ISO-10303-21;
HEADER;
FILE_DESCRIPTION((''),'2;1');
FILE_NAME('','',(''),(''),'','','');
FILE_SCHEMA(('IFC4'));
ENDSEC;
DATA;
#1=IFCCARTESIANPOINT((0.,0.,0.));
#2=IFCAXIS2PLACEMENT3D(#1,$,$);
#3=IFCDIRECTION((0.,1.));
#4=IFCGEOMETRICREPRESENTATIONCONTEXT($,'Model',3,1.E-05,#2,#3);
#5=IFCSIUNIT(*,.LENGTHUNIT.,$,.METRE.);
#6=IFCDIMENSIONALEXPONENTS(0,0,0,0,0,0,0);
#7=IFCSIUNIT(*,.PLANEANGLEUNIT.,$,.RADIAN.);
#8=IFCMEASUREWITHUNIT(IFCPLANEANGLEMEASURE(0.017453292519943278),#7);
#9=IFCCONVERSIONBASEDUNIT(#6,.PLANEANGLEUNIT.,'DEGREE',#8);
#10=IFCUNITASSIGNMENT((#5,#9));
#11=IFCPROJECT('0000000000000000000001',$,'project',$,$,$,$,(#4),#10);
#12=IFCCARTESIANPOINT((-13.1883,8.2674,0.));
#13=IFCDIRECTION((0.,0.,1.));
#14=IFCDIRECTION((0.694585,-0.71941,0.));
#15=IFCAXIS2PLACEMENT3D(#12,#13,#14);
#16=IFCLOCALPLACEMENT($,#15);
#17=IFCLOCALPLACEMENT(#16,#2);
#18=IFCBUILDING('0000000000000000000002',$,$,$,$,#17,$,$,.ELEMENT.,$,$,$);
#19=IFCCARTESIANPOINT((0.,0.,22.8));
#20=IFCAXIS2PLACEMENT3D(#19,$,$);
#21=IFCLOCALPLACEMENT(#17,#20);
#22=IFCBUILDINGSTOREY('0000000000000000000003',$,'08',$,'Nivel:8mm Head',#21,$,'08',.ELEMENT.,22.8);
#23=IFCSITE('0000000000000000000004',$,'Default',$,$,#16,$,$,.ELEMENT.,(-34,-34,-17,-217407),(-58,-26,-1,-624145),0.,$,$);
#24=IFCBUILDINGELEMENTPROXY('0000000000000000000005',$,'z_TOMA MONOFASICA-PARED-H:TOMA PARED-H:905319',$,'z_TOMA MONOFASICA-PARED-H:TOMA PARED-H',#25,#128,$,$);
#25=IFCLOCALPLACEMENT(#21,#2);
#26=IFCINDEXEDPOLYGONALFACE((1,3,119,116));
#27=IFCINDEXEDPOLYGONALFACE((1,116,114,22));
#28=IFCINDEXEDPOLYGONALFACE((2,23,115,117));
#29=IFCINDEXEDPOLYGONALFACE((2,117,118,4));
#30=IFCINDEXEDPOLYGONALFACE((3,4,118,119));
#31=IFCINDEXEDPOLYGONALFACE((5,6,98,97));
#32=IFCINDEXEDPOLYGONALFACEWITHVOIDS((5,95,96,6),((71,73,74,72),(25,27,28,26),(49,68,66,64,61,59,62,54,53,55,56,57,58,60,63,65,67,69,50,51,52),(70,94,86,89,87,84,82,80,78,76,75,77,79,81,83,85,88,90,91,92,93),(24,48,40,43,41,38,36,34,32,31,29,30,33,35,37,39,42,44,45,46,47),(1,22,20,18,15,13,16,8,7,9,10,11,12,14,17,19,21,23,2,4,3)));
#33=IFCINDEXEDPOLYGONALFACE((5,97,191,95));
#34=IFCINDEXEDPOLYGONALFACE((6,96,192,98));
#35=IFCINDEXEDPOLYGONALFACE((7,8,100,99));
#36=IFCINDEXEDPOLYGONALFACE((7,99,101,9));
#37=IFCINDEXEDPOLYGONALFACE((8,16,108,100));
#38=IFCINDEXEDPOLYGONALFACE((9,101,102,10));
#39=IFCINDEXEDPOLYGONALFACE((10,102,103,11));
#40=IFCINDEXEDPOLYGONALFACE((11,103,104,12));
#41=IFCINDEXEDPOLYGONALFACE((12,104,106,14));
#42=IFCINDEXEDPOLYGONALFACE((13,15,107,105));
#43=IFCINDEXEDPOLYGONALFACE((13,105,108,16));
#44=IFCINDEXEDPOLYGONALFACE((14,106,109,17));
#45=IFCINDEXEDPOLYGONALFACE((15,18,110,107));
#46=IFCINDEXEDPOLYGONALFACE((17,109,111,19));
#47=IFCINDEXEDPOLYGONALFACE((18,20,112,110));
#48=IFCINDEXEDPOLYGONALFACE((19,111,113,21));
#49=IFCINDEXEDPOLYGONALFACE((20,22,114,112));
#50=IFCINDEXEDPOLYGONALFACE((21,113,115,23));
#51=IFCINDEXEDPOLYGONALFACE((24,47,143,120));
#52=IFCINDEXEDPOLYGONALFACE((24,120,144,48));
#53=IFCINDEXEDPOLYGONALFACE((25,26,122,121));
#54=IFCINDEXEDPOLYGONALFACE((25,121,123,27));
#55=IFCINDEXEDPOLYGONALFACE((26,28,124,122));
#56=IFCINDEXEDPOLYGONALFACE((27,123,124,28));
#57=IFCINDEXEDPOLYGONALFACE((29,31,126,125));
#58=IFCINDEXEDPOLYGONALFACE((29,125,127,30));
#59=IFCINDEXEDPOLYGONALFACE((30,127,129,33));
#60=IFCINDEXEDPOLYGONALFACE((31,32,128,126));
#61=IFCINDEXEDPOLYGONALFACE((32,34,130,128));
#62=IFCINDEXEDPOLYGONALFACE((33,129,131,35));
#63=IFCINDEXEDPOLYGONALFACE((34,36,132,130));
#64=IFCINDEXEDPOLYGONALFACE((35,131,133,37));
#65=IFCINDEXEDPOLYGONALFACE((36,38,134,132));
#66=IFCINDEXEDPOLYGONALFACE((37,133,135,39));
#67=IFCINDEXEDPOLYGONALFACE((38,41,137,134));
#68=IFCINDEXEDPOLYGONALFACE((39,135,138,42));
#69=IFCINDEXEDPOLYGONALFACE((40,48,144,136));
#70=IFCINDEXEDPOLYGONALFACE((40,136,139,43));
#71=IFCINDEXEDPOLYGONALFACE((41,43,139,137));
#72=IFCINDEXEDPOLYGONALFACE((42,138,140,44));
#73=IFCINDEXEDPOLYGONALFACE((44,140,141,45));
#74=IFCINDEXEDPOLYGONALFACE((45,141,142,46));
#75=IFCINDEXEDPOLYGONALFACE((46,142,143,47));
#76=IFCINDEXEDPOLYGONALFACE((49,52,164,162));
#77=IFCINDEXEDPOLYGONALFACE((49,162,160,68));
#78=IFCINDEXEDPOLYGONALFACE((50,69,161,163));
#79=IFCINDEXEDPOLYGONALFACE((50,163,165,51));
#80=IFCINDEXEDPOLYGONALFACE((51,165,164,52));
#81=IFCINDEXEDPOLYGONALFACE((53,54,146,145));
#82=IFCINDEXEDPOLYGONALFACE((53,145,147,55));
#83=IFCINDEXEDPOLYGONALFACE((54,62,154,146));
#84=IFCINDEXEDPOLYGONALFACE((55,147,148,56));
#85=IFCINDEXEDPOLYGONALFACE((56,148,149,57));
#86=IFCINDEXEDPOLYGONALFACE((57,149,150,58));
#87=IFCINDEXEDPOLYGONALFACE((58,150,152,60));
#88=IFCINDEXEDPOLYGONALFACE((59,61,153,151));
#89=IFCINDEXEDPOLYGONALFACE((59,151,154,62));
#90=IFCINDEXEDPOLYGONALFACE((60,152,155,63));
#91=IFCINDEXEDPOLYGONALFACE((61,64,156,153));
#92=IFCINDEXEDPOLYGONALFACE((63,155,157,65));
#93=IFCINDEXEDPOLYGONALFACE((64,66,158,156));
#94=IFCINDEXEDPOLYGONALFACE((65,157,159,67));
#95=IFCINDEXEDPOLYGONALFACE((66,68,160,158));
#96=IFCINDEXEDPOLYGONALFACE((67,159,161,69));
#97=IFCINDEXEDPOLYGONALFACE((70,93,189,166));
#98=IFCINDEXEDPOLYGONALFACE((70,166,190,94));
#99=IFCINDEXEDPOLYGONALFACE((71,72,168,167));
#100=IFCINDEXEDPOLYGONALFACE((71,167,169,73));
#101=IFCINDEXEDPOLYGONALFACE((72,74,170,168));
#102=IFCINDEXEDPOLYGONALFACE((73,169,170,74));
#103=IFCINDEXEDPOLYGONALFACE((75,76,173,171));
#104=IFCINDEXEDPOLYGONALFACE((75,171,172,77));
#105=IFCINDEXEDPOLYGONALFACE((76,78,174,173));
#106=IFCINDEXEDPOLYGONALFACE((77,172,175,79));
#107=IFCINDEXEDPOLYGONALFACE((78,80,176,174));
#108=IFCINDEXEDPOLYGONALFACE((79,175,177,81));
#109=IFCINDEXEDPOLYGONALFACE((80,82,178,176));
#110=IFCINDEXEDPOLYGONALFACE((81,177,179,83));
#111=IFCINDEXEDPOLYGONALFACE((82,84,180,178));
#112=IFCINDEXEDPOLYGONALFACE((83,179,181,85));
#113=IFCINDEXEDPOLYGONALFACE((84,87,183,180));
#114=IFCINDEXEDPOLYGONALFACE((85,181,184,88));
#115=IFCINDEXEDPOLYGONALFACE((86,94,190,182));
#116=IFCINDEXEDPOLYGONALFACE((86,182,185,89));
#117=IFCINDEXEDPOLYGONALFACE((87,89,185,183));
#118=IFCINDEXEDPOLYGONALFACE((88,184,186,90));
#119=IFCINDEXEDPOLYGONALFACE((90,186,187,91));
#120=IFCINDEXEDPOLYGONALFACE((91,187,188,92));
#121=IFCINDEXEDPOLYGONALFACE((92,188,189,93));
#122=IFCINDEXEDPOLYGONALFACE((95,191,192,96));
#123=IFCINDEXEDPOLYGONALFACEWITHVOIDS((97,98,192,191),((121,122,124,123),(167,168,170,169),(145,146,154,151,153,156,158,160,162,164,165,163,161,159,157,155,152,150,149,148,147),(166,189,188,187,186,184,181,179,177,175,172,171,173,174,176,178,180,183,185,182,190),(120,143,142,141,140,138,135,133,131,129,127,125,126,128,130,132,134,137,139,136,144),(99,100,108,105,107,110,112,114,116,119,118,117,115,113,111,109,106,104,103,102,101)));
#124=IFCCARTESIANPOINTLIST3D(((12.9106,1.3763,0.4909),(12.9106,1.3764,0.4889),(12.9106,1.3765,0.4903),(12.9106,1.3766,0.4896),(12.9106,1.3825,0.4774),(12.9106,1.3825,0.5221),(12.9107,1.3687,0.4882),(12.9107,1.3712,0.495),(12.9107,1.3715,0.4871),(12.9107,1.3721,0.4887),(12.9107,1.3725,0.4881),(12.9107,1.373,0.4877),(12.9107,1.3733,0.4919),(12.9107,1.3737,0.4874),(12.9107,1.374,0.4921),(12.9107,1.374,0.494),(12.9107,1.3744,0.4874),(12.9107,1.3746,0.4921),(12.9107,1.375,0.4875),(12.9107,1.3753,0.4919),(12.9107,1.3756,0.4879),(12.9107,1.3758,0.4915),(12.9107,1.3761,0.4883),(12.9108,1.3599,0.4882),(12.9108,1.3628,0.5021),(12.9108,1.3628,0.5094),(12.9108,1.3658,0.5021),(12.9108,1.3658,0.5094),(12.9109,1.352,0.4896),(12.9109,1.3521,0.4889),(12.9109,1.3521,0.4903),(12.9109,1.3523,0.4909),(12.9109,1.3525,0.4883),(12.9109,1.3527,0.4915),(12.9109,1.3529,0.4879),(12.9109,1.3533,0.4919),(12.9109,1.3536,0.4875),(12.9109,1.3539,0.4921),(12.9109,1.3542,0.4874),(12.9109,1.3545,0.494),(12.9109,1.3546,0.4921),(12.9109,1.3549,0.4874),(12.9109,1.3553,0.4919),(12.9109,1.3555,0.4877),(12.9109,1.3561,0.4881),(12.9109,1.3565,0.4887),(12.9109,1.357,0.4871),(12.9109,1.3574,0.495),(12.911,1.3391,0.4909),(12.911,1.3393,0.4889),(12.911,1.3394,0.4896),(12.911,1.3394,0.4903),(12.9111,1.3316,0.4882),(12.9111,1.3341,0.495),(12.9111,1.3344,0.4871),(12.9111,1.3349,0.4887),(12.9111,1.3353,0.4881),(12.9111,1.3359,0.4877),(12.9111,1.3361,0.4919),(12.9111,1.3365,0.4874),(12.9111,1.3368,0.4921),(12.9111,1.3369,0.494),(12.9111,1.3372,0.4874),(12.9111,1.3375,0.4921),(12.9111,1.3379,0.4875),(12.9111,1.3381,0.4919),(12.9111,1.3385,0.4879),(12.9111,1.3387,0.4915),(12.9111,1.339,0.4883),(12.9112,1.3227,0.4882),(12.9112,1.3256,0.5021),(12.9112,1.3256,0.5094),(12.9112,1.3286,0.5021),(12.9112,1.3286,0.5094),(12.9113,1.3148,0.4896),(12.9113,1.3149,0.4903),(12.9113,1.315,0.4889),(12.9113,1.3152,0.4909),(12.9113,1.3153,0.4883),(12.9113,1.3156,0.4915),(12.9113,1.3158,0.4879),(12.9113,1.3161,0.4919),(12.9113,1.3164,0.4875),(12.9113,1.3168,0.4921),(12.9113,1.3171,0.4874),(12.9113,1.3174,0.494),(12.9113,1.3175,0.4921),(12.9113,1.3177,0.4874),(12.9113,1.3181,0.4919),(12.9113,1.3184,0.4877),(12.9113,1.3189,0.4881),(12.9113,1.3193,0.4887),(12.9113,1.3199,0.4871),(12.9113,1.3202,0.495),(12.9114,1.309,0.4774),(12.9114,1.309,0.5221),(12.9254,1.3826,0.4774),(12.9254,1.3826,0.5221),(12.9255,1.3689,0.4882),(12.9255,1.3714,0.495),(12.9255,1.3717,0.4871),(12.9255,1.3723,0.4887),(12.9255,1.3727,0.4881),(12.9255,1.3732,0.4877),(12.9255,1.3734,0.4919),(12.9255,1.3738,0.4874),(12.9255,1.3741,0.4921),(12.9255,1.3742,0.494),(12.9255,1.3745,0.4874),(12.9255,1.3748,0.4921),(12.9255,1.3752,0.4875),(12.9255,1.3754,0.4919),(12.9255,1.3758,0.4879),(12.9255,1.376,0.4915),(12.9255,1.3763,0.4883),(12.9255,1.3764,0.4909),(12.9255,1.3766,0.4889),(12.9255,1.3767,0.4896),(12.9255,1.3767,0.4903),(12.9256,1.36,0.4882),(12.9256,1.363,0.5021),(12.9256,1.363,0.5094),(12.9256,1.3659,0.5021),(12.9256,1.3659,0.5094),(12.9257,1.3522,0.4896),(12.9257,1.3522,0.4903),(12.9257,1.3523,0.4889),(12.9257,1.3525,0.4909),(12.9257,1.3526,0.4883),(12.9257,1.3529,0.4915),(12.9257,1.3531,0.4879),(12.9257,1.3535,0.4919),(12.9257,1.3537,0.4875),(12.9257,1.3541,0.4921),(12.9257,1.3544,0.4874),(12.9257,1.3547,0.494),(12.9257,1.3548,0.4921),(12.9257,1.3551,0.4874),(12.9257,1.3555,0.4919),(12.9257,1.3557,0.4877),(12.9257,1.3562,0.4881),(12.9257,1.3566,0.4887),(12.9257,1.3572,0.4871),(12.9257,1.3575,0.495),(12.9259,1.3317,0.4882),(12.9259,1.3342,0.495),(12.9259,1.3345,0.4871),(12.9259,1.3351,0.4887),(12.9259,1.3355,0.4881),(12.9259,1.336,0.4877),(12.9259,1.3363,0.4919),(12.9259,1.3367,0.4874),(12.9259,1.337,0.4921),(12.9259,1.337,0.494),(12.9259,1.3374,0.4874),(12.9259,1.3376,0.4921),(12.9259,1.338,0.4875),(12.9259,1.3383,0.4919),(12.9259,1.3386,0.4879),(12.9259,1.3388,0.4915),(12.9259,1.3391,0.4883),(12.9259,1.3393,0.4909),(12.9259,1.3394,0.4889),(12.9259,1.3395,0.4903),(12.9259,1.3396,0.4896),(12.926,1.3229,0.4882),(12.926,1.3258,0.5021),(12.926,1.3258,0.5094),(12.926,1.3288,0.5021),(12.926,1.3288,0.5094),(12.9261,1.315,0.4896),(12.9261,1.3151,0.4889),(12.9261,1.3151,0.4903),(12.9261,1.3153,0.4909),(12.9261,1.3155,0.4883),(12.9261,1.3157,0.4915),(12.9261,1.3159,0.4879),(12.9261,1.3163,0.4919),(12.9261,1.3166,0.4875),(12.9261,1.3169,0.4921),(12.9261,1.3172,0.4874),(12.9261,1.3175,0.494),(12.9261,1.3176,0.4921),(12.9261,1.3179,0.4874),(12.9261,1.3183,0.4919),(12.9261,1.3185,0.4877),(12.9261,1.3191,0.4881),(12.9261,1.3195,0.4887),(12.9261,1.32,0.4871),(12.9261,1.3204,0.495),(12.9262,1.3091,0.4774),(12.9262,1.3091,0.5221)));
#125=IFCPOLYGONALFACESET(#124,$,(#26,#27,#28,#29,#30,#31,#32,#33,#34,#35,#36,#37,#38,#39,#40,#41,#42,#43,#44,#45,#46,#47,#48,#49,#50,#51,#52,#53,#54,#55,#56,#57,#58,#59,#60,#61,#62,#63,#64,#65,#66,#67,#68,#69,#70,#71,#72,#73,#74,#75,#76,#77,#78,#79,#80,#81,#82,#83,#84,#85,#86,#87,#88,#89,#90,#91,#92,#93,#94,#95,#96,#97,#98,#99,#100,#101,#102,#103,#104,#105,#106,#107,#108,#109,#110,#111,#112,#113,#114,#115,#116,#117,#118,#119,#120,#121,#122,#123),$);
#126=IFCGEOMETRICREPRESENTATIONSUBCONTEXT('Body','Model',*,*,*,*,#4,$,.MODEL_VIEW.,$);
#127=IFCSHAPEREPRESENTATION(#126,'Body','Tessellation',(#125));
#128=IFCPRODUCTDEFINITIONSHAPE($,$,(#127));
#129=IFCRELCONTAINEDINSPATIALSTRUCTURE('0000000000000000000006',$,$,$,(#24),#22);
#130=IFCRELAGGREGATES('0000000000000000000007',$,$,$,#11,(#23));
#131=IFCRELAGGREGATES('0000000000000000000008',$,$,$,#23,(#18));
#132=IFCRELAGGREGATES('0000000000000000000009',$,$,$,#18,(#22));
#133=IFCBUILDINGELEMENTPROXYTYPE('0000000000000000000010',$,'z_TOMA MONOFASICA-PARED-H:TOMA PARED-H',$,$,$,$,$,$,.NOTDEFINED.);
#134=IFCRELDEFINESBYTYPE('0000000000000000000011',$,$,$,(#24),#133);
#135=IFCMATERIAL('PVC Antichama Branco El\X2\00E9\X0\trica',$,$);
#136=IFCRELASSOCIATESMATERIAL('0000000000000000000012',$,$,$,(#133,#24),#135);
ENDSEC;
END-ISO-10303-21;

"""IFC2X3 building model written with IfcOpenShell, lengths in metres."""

from ifc_helpers import new_model, entity, si_unit, converted_unit, direction, frame, frame_2d, origin, place, context, subcontext, project, spatial, polyline, circle_curve, parameter, trimmed, segment, composite_curve, outline, extrude, source, transform, mapped, material, type_object, type_shapes, element, save


model = new_model("IFC2X3")

# Units and contexts
model_context = context("Model", 3, precision=1e-05, world=origin(), true_north=direction((0.0, 1.0)))
body_context = subcontext(model_context, "Body", "Model", "MODEL_VIEW")
ifc_project = project(units=[si_unit("LENGTHUNIT", "METRE"), converted_unit("PLANEANGLEUNIT", "DEGREE", entity("IfcPlaneAngleMeasure", 0.017453292519943278), si_unit("PLANEANGLEUNIT", "RADIAN"), dimensions=[0, 0, 0, 0, 0, 0, 0])], contexts=[model_context])

# Site, building, storey
site_placement = place(None, frame((-13.1883, 8.2674, 0.0), z_axis=(0.0, 0.0, 1.0), x_axis=(0.694585, -0.71941, 0.0)))
site = spatial("IfcSite", under=ifc_project, at=site_placement, Name="Default", CompositionType="ELEMENT", RefLatitude=(-34, -34, -17, -217407), RefLongitude=(-58, -26, -1, -624145), RefElevation=0.0)
building_placement = place(site_placement, origin())
building = spatial("IfcBuilding", under=site, at=building_placement, CompositionType="ELEMENT")
storey_placement = place(building_placement, frame((0.0, 0.0, 22.8)))
storey = spatial("IfcBuildingStorey", under=building, at=storey_placement, Name="08", ObjectType="Nivel:8mm Head", LongName="08", CompositionType="ELEMENT", Elevation=22.8)

# Building element proxy
ifc_material_1 = material(Name="PVC Antichama Branco Elétrica")
building_element_proxy_type_1 = type_object("IfcBuildingElementProxyType", Name="z_TOMA MONOFASICA-PARED-H:TOMA PARED-H", PredefinedType="NOTDEFINED", material=ifc_material_1)
shared_shape_1 = source(origin(), body_context, "Body", "SweptSolid", [
    extrude(outline(polyline([(-0.0368, -0.0223), (0.0368, -0.0223), (0.0368, 0.0223), (-0.0368, 0.0223), (-0.0368, -0.0223)]), holes=[composite_curve([segment(polyline([(0.0141, 0.0115), (0.0116, 0.0047)]), True, "CONTINUOUS"), segment(polyline([(0.0116, 0.0047), (0.0088, 0.0057)]), True, "CONTINUOUS"), segment(polyline([(0.0088, 0.0057), (0.0096, 0.0078)]), True, "CONTINUOUS"), segment(trimmed(circle_curve(frame_2d((0.0087, 0.0099), x_axis=(1.0, 0.0)), 0.0024), [parameter(27.118901)], [parameter(292.881099)], True, "PARAMETER"), False, "CONTINUOUS"), segment(polyline([(0.0108, 0.011), (0.0113, 0.0126)]), True, "CONTINUOUS"), segment(polyline([(0.0113, 0.0126), (0.0141, 0.0115)]), True, "CONTINUOUS")], self_intersect=False), composite_curve([segment(polyline([(0.0255, 0.0047), (0.023, 0.0115)]), True, "CONTINUOUS"), segment(polyline([(0.023, 0.0115), (0.0258, 0.0126)]), True, "CONTINUOUS"), segment(polyline([(0.0258, 0.0126), (0.0264, 0.011)]), True, "CONTINUOUS"), segment(trimmed(circle_curve(frame_2d((0.0285, 0.0099), x_axis=(1.0, 0.0)), 0.0024), [parameter(247.118901)], [parameter(152.881099)], True, "PARAMETER"), False, "CONTINUOUS"), segment(polyline([(0.0276, 0.0078), (0.0283, 0.0057)]), True, "CONTINUOUS"), segment(polyline([(0.0283, 0.0057), (0.0255, 0.0047)]), True, "CONTINUOUS")], self_intersect=False), polyline([(0.0201, -0.0024), (0.0201, -0.0097), (0.0171, -0.0097), (0.0171, -0.0024), (0.0201, -0.0024)]), composite_curve([segment(polyline([(-0.0141, 0.0115), (-0.0113, 0.0126)]), True, "CONTINUOUS"), segment(polyline([(-0.0113, 0.0126), (-0.0108, 0.011)]), True, "CONTINUOUS"), segment(trimmed(circle_curve(frame_2d((-0.0087, 0.0099), x_axis=(1.0, 0.0)), 0.0024), [parameter(247.118901)], [parameter(152.881099)], True, "PARAMETER"), False, "CONTINUOUS"), segment(polyline([(-0.0096, 0.0078), (-0.0088, 0.0057)]), True, "CONTINUOUS"), segment(polyline([(-0.0088, 0.0057), (-0.0116, 0.0047)]), True, "CONTINUOUS"), segment(polyline([(-0.0116, 0.0047), (-0.0141, 0.0115)]), True, "CONTINUOUS")], self_intersect=False), composite_curve([segment(polyline([(-0.0255, 0.0047), (-0.0283, 0.0057)]), True, "CONTINUOUS"), segment(polyline([(-0.0283, 0.0057), (-0.0276, 0.0078)]), True, "CONTINUOUS"), segment(trimmed(circle_curve(frame_2d((-0.0285, 0.0099), x_axis=(1.0, 0.0)), 0.0024), [parameter(27.118901)], [parameter(292.881099)], True, "PARAMETER"), False, "CONTINUOUS"), segment(polyline([(-0.0264, 0.011), (-0.0258, 0.0126)]), True, "CONTINUOUS"), segment(polyline([(-0.0258, 0.0126), (-0.023, 0.0115)]), True, "CONTINUOUS"), segment(polyline([(-0.023, 0.0115), (-0.0255, 0.0047)]), True, "CONTINUOUS")], self_intersect=False), polyline([(-0.0201, -0.0024), (-0.0171, -0.0024), (-0.0171, -0.0097), (-0.0201, -0.0097), (-0.0201, -0.0024)])]), frame((0.0, -0.005, 0.0223), z_axis=(0.0, 1.0, 0.0), x_axis=(1.0, 0.0, 0.0)), (0.0, 0.0, 1.0), 0.0148),
])
type_shapes(building_element_proxy_type_1, [shared_shape_1])
for number, where, z_axis, x_axis, name in (
    (1, (12.9208, 1.3458, 0.4774), (0.0, 0.0, 1.0), (-0.010773, 0.999942, 0.0), "z_TOMA MONOFASICA-PARED-H:TOMA PARED-H:905319"),
):
    element("IfcBuildingElementProxy", number, at=place(storey_placement, frame(where, z_axis=z_axis, x_axis=x_axis)), inside=storey, type_object=building_element_proxy_type_1, material=ifc_material_1, Name=name, ObjectType="z_TOMA MONOFASICA-PARED-H:TOMA PARED-H", context=body_context, shape_type="MappedRepresentation", body=[
        mapped(shared_shape_1, transform((0.0, 0.0, 0.0), scale=1.0)),
    ])

save(model, "model.ifc")
